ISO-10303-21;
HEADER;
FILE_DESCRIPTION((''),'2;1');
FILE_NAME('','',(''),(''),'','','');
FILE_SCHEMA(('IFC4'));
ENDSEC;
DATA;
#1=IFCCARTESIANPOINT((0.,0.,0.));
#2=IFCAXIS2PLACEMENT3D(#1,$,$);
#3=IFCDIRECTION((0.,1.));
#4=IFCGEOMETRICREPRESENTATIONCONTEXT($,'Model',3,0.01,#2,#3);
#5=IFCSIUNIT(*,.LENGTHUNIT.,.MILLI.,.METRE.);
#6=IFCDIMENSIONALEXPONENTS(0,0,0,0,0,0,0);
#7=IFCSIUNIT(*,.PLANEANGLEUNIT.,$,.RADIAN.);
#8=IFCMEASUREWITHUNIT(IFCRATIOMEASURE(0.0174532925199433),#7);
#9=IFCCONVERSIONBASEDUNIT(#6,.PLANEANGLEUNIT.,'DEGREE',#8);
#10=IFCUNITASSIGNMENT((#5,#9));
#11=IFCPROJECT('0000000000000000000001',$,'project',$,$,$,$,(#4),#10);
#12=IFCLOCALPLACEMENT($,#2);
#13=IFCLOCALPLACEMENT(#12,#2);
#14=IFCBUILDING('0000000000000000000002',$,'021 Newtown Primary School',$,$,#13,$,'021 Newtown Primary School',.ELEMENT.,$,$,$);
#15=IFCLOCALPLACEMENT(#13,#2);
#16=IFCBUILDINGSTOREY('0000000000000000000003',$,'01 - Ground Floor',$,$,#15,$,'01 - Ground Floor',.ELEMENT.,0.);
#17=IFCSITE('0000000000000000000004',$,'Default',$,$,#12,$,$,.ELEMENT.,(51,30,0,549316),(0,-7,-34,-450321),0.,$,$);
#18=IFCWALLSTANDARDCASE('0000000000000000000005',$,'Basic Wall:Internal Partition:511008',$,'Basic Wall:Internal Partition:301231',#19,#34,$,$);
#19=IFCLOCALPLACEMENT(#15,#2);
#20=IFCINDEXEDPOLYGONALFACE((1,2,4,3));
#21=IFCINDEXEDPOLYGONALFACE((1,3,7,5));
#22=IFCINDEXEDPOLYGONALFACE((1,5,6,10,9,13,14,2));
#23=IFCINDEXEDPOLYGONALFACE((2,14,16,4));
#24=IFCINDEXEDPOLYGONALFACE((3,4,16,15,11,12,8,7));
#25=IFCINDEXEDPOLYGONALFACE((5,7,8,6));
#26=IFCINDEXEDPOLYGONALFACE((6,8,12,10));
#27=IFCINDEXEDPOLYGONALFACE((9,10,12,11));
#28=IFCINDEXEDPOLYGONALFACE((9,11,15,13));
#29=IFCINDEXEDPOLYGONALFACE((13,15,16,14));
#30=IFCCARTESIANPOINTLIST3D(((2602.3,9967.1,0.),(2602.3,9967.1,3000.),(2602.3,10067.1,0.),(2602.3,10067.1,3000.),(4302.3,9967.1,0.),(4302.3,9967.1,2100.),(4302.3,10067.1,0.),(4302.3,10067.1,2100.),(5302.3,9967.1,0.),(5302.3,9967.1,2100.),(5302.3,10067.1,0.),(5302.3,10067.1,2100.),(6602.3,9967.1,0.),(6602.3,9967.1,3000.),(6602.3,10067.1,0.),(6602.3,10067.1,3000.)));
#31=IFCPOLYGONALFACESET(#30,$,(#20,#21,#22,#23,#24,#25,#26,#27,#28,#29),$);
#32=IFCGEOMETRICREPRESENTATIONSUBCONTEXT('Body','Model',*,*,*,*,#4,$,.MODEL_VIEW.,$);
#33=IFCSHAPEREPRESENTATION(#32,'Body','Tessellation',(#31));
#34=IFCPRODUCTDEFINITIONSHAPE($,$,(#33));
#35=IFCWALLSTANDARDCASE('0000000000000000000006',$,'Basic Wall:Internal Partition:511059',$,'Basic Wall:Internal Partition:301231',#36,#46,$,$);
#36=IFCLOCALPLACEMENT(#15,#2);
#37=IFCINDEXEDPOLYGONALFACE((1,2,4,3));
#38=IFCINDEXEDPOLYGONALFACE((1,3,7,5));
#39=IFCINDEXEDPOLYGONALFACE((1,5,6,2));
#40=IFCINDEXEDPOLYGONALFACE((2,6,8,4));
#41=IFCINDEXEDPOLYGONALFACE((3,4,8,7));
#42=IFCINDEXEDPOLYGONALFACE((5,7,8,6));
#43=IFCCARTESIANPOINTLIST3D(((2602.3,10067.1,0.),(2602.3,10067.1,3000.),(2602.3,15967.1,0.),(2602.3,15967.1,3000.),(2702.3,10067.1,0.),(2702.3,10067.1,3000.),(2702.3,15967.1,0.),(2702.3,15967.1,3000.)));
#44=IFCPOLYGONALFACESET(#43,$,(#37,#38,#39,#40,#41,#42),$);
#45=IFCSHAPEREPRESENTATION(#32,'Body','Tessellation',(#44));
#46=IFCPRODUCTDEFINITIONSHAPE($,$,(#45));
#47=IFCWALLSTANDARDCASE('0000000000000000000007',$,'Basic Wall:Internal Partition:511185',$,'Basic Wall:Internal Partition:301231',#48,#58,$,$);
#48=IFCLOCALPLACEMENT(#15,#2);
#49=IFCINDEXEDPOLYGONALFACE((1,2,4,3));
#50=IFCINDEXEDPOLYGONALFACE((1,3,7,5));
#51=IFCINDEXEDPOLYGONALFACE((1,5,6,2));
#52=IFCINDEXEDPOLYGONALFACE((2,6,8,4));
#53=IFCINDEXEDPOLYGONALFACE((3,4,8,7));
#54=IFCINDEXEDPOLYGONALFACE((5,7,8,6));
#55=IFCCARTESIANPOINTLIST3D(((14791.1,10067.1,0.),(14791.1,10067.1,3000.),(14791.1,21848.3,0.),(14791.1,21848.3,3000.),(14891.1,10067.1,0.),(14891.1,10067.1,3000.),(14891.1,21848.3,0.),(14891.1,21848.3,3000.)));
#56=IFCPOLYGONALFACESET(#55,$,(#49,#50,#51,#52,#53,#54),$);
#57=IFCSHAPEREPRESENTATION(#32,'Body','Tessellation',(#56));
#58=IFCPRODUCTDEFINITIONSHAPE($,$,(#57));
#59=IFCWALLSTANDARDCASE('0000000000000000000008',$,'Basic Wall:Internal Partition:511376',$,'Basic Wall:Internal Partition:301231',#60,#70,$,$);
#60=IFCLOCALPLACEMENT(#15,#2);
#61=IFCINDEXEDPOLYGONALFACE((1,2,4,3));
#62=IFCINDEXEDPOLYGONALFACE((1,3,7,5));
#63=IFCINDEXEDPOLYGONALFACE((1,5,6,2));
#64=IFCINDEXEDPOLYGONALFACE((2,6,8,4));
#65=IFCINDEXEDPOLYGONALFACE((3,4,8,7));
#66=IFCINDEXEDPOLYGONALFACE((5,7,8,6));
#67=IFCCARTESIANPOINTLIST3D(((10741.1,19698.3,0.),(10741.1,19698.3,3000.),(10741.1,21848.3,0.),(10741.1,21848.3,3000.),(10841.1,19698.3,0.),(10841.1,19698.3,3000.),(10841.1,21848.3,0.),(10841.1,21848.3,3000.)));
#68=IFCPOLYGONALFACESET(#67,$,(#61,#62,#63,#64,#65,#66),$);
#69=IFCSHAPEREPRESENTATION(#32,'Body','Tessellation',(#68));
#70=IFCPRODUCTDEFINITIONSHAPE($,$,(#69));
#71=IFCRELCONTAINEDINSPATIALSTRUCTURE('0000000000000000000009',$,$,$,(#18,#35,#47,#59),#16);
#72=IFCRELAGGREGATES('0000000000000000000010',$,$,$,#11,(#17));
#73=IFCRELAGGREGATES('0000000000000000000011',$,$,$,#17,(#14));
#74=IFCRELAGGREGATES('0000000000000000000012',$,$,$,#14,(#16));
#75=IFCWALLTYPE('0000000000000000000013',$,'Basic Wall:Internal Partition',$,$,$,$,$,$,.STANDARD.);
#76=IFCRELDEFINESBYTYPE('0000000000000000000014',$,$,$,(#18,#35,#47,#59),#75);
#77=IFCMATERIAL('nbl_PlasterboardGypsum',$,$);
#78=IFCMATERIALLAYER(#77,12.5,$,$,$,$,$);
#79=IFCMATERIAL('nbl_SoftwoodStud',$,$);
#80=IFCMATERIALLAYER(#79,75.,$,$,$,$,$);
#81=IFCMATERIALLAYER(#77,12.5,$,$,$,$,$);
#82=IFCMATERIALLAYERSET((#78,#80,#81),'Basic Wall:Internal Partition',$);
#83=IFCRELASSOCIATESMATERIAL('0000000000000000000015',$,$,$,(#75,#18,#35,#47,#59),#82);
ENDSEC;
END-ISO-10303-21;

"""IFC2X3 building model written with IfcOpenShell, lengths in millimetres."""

from ifc_helpers import new_model, entity, si_unit, converted_unit, direction, frame, frame_2d, origin, place, context, subcontext, project, spatial, rectangle, extrude, material, layer, layer_set, layer_usage, type_object, element, save


model = new_model("IFC2X3")

# Units and contexts
model_context = context("Model", 3, precision=0.01, world=origin(), true_north=direction((0.0, 1.0)))
body_context = subcontext(model_context, "Body", "Model", "MODEL_VIEW")
ifc_project = project(units=[si_unit("LENGTHUNIT", "METRE", prefix="MILLI"), converted_unit("PLANEANGLEUNIT", "DEGREE", entity("IfcRatioMeasure", 0.0174532925199433), si_unit("PLANEANGLEUNIT", "RADIAN"), dimensions=[0, 0, 0, 0, 0, 0, 0])], contexts=[model_context])

# Site, building, storey
site_placement = place(None, origin())
site = spatial("IfcSite", under=ifc_project, at=site_placement, Name="Default", CompositionType="ELEMENT", RefLatitude=(51, 30, 0, 549316), RefLongitude=(0, -7, -34, -450321), RefElevation=0.0)
building_placement = place(site_placement, origin())
building = spatial("IfcBuilding", under=site, at=building_placement, Name="021 Newtown Primary School", LongName="021 Newtown Primary School", CompositionType="ELEMENT")
storey_placement = place(building_placement, origin())
storey = spatial("IfcBuildingStorey", under=building, at=storey_placement, Name="01 - Ground Floor", LongName="01 - Ground Floor", CompositionType="ELEMENT", Elevation=0.0)

# Shared definitions
ifc_material_1 = material(Name="nbl_PlasterboardGypsum")
ifc_layer_1 = layer(ifc_material_1, 12.5)
ifc_material_2 = material(Name="nbl_SoftwoodStud")
ifc_layer_2 = layer(ifc_material_2, 75.0)
ifc_layer_3 = layer(ifc_material_1, 12.5)
ifc_layer_set_1 = layer_set([ifc_layer_1, ifc_layer_2, ifc_layer_3], Name="Basic Wall:Internal Partition")
wall_type_1 = type_object("IfcWallType", Name="Basic Wall:Internal Partition", PredefinedType="STANDARD", material=ifc_layer_set_1)

# Wall, opening
ifc_layer_usage_1 = layer_usage(ifc_layer_set_1, "AXIS2", "NEGATIVE", 50.0)
wall_1_placement = place(storey_placement, frame((6602.3, 10017.1, 0.0), z_axis=(0.0, 0.0, 1.0), x_axis=(-1.0, 0.0, 0.0)))
wall_1 = element("IfcWallStandardCase", 1, at=wall_1_placement, inside=storey, type_object=wall_type_1, material=ifc_layer_usage_1, Name="Basic Wall:Internal Partition:511008", ObjectType="Basic Wall:Internal Partition:301231", context=body_context, shape_type="SweptSolid", body=[
    extrude(rectangle(XDim=4000.0, YDim=100.0, at=frame_2d((2000.0, 0.0), x_axis=(-1.0, 0.0))), origin(), (0.0, 0.0, 1.0), 3000.0),
])
opening_1_placement = place(wall_1_placement, origin())
element("IfcOpeningElement", 2, at=opening_1_placement, cuts=wall_1, ObjectType="Opening", context=body_context, shape_type="SweptSolid", body=[
    extrude(rectangle(XDim=2100.0, YDim=1000.0, at=frame_2d((0.0, 0.0), x_axis=(1.0, 0.0))), frame((1800.0, -1474.0, 1050.0), z_axis=(0.0, 1.0, 0.0), x_axis=(0.0, 0.0, 1.0)), (0.0, 0.0, 1.0), 3048.0),
])

# Walls
ifc_layer_usage_2 = layer_usage(ifc_layer_set_1, "AXIS2", "NEGATIVE", 50.0)
wall_2_placement = place(storey_placement, frame((2652.3, 10067.1, 0.0), z_axis=(0.0, 0.0, 1.0), x_axis=(0.0, 1.0, 0.0)))
element("IfcWallStandardCase", 3, at=wall_2_placement, inside=storey, type_object=wall_type_1, material=ifc_layer_usage_2, Name="Basic Wall:Internal Partition:511059", ObjectType="Basic Wall:Internal Partition:301231", context=body_context, shape_type="SweptSolid", body=[
    extrude(rectangle(XDim=5900.0, YDim=100.0, at=frame_2d((2950.0, 0.0), x_axis=(-1.0, 0.0))), origin(), (0.0, 0.0, 1.0), 3000.0),
])
ifc_layer_usage_3 = layer_usage(ifc_layer_set_1, "AXIS2", "NEGATIVE", 50.0)
wall_3_placement = place(storey_placement, frame((14841.1, 10067.1, 0.0), z_axis=(0.0, 0.0, 1.0), x_axis=(0.0, 1.0, 0.0)))
element("IfcWallStandardCase", 4, at=wall_3_placement, inside=storey, type_object=wall_type_1, material=ifc_layer_usage_3, Name="Basic Wall:Internal Partition:511185", ObjectType="Basic Wall:Internal Partition:301231", context=body_context, shape_type="SweptSolid", body=[
    extrude(rectangle(XDim=11781.2, YDim=100.0, at=frame_2d((5890.6, 0.0), x_axis=(-1.0, 0.0))), origin(), (0.0, 0.0, 1.0), 3000.0),
])

# Wall
ifc_layer_usage_4 = layer_usage(ifc_layer_set_1, "AXIS2", "NEGATIVE", 50.0)
wall_4_placement = place(storey_placement, frame((10791.1, 21848.3, 0.0), z_axis=(0.0, 0.0, 1.0), x_axis=(0.0, -1.0, 0.0)))
element("IfcWallStandardCase", 5, at=wall_4_placement, inside=storey, type_object=wall_type_1, material=ifc_layer_usage_4, Name="Basic Wall:Internal Partition:511376", ObjectType="Basic Wall:Internal Partition:301231", context=body_context, shape_type="SweptSolid", body=[
    extrude(rectangle(XDim=2150.0, YDim=100.0, at=frame_2d((1075.0, 0.0), x_axis=(-1.0, 0.0))), origin(), (0.0, 0.0, 1.0), 3000.0),
])

save(model, "model.ifc")
